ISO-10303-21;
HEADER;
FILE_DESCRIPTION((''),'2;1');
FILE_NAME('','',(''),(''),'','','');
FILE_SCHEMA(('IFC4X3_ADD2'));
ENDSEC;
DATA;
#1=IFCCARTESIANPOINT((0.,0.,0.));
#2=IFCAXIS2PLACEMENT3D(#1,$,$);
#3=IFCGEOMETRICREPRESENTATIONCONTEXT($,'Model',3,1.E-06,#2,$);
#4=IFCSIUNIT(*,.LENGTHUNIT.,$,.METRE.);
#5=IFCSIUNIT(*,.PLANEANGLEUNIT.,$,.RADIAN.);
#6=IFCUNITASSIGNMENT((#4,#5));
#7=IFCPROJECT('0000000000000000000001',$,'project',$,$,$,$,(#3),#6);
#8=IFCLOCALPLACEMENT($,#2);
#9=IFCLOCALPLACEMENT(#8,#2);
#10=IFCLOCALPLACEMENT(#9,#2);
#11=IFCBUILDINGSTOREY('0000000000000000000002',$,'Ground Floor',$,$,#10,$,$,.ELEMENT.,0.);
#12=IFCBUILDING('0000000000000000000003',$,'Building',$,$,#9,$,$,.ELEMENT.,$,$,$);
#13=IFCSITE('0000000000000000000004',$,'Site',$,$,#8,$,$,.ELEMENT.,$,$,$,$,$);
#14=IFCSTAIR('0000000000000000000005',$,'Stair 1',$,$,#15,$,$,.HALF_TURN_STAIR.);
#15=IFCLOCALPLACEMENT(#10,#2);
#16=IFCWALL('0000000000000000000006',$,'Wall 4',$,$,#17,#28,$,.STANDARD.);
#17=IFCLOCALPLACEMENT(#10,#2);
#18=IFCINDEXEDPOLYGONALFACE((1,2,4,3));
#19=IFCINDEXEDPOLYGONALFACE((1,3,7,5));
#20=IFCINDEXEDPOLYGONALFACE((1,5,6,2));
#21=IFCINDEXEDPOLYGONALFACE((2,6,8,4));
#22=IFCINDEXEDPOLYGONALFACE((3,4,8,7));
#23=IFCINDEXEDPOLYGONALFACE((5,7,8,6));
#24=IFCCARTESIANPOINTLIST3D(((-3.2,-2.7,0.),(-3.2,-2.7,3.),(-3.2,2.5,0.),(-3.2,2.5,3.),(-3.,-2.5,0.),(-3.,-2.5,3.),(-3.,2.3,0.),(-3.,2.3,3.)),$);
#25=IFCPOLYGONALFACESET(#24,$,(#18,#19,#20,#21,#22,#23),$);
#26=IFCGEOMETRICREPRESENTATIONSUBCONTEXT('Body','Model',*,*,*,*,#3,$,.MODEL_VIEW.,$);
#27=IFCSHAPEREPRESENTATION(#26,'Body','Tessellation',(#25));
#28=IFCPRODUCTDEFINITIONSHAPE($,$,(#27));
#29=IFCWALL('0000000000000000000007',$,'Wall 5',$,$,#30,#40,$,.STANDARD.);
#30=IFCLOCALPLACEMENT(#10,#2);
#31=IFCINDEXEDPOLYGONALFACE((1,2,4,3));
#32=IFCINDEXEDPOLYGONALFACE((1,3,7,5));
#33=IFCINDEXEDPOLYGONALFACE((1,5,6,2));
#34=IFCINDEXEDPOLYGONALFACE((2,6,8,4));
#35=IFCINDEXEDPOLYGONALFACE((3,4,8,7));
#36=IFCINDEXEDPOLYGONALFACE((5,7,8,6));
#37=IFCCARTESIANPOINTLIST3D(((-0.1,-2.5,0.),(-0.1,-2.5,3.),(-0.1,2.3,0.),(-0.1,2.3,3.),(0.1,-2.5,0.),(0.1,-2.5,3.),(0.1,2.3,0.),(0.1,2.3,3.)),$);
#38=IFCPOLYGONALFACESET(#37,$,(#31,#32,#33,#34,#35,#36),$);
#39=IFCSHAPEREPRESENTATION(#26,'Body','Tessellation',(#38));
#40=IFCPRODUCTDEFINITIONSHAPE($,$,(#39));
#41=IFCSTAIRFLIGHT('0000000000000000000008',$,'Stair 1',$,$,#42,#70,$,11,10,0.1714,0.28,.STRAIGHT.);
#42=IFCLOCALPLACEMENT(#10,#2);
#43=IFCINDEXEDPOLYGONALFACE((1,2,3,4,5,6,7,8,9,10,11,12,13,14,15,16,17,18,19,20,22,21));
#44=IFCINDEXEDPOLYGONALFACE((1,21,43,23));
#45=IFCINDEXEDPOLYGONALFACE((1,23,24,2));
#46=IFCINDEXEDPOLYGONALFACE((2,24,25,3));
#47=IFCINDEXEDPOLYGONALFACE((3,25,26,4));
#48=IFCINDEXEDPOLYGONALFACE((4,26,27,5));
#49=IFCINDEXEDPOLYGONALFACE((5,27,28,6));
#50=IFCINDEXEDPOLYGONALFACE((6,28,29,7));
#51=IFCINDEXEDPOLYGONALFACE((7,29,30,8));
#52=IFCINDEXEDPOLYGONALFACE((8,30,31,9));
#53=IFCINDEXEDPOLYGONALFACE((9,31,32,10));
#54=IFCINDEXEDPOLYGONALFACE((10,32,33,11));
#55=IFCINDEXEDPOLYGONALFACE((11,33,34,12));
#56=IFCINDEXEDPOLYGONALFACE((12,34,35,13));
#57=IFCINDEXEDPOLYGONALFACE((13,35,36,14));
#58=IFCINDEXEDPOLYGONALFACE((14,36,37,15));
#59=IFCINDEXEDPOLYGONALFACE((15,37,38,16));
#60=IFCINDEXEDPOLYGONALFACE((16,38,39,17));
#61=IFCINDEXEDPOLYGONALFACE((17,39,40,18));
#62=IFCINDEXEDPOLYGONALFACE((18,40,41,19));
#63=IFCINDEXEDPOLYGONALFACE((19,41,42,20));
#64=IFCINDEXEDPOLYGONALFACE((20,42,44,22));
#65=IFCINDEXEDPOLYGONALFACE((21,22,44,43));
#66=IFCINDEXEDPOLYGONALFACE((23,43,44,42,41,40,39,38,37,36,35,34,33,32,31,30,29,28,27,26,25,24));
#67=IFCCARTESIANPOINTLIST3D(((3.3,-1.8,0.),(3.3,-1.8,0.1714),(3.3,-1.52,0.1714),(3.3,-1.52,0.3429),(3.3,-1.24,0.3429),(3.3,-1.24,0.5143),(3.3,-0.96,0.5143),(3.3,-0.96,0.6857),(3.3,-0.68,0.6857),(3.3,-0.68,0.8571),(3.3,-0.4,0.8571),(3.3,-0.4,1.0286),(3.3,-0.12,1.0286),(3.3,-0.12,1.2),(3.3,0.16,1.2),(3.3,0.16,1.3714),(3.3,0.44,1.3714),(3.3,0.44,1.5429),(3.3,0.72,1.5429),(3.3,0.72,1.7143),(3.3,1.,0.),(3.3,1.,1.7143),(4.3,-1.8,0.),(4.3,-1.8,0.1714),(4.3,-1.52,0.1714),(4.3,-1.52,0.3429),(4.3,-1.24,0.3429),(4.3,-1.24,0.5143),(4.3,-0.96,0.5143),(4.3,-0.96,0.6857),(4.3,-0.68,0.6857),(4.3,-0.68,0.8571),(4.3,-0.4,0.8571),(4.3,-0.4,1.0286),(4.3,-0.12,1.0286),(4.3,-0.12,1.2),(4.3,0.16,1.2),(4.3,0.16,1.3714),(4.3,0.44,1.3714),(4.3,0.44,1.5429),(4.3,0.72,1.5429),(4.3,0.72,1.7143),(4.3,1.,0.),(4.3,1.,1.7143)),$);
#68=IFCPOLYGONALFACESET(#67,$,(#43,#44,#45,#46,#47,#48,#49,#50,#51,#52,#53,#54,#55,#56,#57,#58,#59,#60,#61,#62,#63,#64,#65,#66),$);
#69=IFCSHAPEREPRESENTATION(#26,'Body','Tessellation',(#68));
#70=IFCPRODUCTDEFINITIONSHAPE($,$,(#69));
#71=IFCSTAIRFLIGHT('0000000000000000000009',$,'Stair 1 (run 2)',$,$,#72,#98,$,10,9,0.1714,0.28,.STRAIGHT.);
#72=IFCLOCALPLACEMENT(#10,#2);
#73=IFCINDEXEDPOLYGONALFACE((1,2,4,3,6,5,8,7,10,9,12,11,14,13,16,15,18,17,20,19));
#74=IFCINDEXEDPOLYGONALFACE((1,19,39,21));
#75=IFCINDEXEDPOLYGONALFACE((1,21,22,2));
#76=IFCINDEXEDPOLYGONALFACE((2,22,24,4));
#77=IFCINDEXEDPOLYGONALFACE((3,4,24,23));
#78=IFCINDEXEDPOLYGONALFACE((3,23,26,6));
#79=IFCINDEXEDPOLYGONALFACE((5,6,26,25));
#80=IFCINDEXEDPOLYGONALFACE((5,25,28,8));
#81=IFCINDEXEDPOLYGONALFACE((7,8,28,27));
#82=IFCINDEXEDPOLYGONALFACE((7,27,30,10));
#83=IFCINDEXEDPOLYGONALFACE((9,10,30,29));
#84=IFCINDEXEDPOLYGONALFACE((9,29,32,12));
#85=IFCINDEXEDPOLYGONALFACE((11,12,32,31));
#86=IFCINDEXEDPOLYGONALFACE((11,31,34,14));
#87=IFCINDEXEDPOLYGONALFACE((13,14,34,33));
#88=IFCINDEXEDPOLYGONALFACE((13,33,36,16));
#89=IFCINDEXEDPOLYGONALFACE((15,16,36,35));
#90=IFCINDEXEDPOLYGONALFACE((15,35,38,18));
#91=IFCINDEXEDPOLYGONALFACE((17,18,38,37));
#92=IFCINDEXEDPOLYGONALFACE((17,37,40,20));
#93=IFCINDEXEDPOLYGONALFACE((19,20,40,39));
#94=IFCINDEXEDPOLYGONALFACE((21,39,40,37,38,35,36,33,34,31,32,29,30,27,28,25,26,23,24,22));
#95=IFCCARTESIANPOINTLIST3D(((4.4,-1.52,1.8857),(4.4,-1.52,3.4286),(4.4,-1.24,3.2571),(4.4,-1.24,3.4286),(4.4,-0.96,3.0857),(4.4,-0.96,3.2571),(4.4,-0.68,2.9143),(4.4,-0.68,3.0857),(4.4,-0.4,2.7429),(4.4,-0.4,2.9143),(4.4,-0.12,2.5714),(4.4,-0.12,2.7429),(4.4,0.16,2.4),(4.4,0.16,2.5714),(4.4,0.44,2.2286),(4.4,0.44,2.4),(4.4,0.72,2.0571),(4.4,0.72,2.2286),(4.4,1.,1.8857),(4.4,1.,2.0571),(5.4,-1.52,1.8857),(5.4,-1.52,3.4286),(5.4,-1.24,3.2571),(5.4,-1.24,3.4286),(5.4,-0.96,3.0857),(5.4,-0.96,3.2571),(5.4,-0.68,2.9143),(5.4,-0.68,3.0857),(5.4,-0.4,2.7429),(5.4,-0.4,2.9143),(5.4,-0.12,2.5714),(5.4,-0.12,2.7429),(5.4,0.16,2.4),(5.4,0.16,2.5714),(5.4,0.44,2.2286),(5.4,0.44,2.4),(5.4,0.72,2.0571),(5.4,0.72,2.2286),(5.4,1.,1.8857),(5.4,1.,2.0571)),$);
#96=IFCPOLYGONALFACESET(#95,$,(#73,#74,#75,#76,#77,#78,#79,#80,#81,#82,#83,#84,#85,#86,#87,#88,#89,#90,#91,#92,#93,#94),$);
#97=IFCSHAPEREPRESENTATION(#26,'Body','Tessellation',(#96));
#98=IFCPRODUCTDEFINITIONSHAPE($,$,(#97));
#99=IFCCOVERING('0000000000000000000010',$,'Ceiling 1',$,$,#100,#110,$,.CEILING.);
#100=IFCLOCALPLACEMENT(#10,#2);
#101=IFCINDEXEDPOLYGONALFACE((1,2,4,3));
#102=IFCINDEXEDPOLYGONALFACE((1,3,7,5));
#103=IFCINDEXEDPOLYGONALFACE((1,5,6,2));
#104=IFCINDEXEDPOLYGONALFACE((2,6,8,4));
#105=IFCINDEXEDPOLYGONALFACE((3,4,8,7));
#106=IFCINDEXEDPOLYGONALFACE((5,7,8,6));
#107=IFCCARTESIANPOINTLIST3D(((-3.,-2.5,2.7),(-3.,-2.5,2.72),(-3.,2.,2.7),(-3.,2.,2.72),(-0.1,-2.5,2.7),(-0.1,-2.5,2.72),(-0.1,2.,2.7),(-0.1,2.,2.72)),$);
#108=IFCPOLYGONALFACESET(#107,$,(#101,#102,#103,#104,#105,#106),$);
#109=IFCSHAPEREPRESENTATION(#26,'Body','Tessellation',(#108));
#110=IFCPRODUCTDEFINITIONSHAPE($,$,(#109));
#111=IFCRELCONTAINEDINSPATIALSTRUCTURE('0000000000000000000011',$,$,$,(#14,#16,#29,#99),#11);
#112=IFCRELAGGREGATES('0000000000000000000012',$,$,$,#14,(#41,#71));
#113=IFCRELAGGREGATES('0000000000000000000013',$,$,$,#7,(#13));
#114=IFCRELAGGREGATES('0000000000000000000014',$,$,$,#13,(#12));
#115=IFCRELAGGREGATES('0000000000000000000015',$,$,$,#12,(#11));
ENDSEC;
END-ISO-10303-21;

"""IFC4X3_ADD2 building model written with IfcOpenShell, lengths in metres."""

from ifc_helpers import new_model, si_unit, frame, origin, place, context, subcontext, project, spatial, polyline, outline, extrude, element, aggregate, save


model = new_model("IFC4X3_ADD2")

# Units and contexts
model_context = context("Model", 3, precision=1e-06, world=origin())
body_context = subcontext(model_context, "Body", "Model", "MODEL_VIEW")
ifc_project = project(units=[si_unit("LENGTHUNIT", "METRE"), si_unit("PLANEANGLEUNIT", "RADIAN")], contexts=[model_context])

# Site, building, storey
site_placement = place(None, origin())
site = spatial("IfcSite", under=ifc_project, at=site_placement, Name="Site", CompositionType="ELEMENT")
building_placement = place(site_placement, origin())
building = spatial("IfcBuilding", under=site, at=building_placement, Name="Building", CompositionType="ELEMENT")
storey_placement = place(building_placement, origin())
storey = spatial("IfcBuildingStorey", under=building, at=storey_placement, Name="Ground Floor", CompositionType="ELEMENT", Elevation=0.0)

# Stair
stair_placement = place(storey_placement, origin())
stair = element("IfcStair", 1, at=stair_placement, inside=storey, Name="Stair 1", PredefinedType="HALF_TURN_STAIR")

# Walls
wall_1_placement = place(storey_placement, origin())
element("IfcWall", 2, at=wall_1_placement, inside=storey, Name="Wall 4", PredefinedType="STANDARD", context=body_context, shape_type="SweptSolid", body=[
    extrude(outline(polyline([(-3.0, 2.3), (-3.0, -2.5), (-3.2, -2.7), (-3.2, 2.5), (-3.0, 2.3)])), origin(), (0.0, 0.0, 1.0), 3.0),
])
wall_2_placement = place(storey_placement, origin())
element("IfcWall", 3, at=wall_2_placement, inside=storey, Name="Wall 5", PredefinedType="STANDARD", context=body_context, shape_type="SweptSolid", body=[
    extrude(outline(polyline([(-0.1, -2.5), (-0.1, 2.3), (0.1, 2.3), (0.1, -2.5), (-0.1, -2.5)])), origin(), (0.0, 0.0, 1.0), 3.0),
])

# Stair flights
stair_flight_1_placement = place(storey_placement, origin())
stair_flight_1 = element("IfcStairFlight", 4, at=stair_flight_1_placement, Name="Stair 1", NumberOfRisers=11, NumberOfTreads=10, PredefinedType="STRAIGHT", RiserHeight=0.1714, TreadLength=0.28, context=body_context, shape_type="SweptSolid", body=[
    extrude(outline(polyline([(0.0, 0.0), (0.0, 0.1714), (0.28, 0.1714), (0.28, 0.3429), (0.56, 0.3429), (0.56, 0.5143), (0.84, 0.5143), (0.84, 0.6857), (1.12, 0.6857), (1.12, 0.8571), (1.4, 0.8571), (1.4, 1.0286), (1.68, 1.0286), (1.68, 1.2), (1.96, 1.2), (1.96, 1.3714), (2.24, 1.3714), (2.24, 1.5429), (2.52, 1.5429), (2.52, 1.7143), (2.8, 1.7143), (2.8, 0.0), (0.0, 0.0)])), frame((3.3, -1.8, 0.0), z_axis=(1.0, 0.0, 0.0), x_axis=(0.0, 1.0, 0.0)), (0.0, 0.0, 1.0), 1.0),
])
stair_flight_2_placement = place(storey_placement, origin())
stair_flight_2 = element("IfcStairFlight", 5, at=stair_flight_2_placement, Name="Stair 1 (run 2)", NumberOfRisers=10, NumberOfTreads=9, PredefinedType="STRAIGHT", RiserHeight=0.1714, TreadLength=0.28, context=body_context, shape_type="SweptSolid", body=[
    extrude(outline(polyline([(0.0, 0.0), (0.0, 0.1714), (0.28, 0.1714), (0.28, 0.3429), (0.56, 0.3429), (0.56, 0.5143), (0.84, 0.5143), (0.84, 0.6857), (1.12, 0.6857), (1.12, 0.8571), (1.4, 0.8571), (1.4, 1.0286), (1.68, 1.0286), (1.68, 1.2), (1.96, 1.2), (1.96, 1.3714), (2.24, 1.3714), (2.24, 1.5429), (2.52, 1.5429), (2.52, 0.0), (0.0, 0.0)])), frame((5.4, 1.0, 1.8857), z_axis=(-1.0, 0.0, 0.0), x_axis=(0.0, -1.0, 0.0)), (0.0, 0.0, 1.0), 1.0),
])
aggregate(stair, [stair_flight_1, stair_flight_2])

# Covering
covering_placement = place(storey_placement, origin())
element("IfcCovering", 6, at=covering_placement, inside=storey, Name="Ceiling 1", PredefinedType="CEILING", context=body_context, shape_type="SweptSolid", body=[
    extrude(outline(polyline([(-3.0, 2.0), (-3.0, -2.5), (-0.1, -2.5), (-0.1, 2.0), (-3.0, 2.0)])), frame((0.0, 0.0, 2.7)), (0.0, 0.0, 1.0), 0.02),
])

save(model, "model.ifc")
